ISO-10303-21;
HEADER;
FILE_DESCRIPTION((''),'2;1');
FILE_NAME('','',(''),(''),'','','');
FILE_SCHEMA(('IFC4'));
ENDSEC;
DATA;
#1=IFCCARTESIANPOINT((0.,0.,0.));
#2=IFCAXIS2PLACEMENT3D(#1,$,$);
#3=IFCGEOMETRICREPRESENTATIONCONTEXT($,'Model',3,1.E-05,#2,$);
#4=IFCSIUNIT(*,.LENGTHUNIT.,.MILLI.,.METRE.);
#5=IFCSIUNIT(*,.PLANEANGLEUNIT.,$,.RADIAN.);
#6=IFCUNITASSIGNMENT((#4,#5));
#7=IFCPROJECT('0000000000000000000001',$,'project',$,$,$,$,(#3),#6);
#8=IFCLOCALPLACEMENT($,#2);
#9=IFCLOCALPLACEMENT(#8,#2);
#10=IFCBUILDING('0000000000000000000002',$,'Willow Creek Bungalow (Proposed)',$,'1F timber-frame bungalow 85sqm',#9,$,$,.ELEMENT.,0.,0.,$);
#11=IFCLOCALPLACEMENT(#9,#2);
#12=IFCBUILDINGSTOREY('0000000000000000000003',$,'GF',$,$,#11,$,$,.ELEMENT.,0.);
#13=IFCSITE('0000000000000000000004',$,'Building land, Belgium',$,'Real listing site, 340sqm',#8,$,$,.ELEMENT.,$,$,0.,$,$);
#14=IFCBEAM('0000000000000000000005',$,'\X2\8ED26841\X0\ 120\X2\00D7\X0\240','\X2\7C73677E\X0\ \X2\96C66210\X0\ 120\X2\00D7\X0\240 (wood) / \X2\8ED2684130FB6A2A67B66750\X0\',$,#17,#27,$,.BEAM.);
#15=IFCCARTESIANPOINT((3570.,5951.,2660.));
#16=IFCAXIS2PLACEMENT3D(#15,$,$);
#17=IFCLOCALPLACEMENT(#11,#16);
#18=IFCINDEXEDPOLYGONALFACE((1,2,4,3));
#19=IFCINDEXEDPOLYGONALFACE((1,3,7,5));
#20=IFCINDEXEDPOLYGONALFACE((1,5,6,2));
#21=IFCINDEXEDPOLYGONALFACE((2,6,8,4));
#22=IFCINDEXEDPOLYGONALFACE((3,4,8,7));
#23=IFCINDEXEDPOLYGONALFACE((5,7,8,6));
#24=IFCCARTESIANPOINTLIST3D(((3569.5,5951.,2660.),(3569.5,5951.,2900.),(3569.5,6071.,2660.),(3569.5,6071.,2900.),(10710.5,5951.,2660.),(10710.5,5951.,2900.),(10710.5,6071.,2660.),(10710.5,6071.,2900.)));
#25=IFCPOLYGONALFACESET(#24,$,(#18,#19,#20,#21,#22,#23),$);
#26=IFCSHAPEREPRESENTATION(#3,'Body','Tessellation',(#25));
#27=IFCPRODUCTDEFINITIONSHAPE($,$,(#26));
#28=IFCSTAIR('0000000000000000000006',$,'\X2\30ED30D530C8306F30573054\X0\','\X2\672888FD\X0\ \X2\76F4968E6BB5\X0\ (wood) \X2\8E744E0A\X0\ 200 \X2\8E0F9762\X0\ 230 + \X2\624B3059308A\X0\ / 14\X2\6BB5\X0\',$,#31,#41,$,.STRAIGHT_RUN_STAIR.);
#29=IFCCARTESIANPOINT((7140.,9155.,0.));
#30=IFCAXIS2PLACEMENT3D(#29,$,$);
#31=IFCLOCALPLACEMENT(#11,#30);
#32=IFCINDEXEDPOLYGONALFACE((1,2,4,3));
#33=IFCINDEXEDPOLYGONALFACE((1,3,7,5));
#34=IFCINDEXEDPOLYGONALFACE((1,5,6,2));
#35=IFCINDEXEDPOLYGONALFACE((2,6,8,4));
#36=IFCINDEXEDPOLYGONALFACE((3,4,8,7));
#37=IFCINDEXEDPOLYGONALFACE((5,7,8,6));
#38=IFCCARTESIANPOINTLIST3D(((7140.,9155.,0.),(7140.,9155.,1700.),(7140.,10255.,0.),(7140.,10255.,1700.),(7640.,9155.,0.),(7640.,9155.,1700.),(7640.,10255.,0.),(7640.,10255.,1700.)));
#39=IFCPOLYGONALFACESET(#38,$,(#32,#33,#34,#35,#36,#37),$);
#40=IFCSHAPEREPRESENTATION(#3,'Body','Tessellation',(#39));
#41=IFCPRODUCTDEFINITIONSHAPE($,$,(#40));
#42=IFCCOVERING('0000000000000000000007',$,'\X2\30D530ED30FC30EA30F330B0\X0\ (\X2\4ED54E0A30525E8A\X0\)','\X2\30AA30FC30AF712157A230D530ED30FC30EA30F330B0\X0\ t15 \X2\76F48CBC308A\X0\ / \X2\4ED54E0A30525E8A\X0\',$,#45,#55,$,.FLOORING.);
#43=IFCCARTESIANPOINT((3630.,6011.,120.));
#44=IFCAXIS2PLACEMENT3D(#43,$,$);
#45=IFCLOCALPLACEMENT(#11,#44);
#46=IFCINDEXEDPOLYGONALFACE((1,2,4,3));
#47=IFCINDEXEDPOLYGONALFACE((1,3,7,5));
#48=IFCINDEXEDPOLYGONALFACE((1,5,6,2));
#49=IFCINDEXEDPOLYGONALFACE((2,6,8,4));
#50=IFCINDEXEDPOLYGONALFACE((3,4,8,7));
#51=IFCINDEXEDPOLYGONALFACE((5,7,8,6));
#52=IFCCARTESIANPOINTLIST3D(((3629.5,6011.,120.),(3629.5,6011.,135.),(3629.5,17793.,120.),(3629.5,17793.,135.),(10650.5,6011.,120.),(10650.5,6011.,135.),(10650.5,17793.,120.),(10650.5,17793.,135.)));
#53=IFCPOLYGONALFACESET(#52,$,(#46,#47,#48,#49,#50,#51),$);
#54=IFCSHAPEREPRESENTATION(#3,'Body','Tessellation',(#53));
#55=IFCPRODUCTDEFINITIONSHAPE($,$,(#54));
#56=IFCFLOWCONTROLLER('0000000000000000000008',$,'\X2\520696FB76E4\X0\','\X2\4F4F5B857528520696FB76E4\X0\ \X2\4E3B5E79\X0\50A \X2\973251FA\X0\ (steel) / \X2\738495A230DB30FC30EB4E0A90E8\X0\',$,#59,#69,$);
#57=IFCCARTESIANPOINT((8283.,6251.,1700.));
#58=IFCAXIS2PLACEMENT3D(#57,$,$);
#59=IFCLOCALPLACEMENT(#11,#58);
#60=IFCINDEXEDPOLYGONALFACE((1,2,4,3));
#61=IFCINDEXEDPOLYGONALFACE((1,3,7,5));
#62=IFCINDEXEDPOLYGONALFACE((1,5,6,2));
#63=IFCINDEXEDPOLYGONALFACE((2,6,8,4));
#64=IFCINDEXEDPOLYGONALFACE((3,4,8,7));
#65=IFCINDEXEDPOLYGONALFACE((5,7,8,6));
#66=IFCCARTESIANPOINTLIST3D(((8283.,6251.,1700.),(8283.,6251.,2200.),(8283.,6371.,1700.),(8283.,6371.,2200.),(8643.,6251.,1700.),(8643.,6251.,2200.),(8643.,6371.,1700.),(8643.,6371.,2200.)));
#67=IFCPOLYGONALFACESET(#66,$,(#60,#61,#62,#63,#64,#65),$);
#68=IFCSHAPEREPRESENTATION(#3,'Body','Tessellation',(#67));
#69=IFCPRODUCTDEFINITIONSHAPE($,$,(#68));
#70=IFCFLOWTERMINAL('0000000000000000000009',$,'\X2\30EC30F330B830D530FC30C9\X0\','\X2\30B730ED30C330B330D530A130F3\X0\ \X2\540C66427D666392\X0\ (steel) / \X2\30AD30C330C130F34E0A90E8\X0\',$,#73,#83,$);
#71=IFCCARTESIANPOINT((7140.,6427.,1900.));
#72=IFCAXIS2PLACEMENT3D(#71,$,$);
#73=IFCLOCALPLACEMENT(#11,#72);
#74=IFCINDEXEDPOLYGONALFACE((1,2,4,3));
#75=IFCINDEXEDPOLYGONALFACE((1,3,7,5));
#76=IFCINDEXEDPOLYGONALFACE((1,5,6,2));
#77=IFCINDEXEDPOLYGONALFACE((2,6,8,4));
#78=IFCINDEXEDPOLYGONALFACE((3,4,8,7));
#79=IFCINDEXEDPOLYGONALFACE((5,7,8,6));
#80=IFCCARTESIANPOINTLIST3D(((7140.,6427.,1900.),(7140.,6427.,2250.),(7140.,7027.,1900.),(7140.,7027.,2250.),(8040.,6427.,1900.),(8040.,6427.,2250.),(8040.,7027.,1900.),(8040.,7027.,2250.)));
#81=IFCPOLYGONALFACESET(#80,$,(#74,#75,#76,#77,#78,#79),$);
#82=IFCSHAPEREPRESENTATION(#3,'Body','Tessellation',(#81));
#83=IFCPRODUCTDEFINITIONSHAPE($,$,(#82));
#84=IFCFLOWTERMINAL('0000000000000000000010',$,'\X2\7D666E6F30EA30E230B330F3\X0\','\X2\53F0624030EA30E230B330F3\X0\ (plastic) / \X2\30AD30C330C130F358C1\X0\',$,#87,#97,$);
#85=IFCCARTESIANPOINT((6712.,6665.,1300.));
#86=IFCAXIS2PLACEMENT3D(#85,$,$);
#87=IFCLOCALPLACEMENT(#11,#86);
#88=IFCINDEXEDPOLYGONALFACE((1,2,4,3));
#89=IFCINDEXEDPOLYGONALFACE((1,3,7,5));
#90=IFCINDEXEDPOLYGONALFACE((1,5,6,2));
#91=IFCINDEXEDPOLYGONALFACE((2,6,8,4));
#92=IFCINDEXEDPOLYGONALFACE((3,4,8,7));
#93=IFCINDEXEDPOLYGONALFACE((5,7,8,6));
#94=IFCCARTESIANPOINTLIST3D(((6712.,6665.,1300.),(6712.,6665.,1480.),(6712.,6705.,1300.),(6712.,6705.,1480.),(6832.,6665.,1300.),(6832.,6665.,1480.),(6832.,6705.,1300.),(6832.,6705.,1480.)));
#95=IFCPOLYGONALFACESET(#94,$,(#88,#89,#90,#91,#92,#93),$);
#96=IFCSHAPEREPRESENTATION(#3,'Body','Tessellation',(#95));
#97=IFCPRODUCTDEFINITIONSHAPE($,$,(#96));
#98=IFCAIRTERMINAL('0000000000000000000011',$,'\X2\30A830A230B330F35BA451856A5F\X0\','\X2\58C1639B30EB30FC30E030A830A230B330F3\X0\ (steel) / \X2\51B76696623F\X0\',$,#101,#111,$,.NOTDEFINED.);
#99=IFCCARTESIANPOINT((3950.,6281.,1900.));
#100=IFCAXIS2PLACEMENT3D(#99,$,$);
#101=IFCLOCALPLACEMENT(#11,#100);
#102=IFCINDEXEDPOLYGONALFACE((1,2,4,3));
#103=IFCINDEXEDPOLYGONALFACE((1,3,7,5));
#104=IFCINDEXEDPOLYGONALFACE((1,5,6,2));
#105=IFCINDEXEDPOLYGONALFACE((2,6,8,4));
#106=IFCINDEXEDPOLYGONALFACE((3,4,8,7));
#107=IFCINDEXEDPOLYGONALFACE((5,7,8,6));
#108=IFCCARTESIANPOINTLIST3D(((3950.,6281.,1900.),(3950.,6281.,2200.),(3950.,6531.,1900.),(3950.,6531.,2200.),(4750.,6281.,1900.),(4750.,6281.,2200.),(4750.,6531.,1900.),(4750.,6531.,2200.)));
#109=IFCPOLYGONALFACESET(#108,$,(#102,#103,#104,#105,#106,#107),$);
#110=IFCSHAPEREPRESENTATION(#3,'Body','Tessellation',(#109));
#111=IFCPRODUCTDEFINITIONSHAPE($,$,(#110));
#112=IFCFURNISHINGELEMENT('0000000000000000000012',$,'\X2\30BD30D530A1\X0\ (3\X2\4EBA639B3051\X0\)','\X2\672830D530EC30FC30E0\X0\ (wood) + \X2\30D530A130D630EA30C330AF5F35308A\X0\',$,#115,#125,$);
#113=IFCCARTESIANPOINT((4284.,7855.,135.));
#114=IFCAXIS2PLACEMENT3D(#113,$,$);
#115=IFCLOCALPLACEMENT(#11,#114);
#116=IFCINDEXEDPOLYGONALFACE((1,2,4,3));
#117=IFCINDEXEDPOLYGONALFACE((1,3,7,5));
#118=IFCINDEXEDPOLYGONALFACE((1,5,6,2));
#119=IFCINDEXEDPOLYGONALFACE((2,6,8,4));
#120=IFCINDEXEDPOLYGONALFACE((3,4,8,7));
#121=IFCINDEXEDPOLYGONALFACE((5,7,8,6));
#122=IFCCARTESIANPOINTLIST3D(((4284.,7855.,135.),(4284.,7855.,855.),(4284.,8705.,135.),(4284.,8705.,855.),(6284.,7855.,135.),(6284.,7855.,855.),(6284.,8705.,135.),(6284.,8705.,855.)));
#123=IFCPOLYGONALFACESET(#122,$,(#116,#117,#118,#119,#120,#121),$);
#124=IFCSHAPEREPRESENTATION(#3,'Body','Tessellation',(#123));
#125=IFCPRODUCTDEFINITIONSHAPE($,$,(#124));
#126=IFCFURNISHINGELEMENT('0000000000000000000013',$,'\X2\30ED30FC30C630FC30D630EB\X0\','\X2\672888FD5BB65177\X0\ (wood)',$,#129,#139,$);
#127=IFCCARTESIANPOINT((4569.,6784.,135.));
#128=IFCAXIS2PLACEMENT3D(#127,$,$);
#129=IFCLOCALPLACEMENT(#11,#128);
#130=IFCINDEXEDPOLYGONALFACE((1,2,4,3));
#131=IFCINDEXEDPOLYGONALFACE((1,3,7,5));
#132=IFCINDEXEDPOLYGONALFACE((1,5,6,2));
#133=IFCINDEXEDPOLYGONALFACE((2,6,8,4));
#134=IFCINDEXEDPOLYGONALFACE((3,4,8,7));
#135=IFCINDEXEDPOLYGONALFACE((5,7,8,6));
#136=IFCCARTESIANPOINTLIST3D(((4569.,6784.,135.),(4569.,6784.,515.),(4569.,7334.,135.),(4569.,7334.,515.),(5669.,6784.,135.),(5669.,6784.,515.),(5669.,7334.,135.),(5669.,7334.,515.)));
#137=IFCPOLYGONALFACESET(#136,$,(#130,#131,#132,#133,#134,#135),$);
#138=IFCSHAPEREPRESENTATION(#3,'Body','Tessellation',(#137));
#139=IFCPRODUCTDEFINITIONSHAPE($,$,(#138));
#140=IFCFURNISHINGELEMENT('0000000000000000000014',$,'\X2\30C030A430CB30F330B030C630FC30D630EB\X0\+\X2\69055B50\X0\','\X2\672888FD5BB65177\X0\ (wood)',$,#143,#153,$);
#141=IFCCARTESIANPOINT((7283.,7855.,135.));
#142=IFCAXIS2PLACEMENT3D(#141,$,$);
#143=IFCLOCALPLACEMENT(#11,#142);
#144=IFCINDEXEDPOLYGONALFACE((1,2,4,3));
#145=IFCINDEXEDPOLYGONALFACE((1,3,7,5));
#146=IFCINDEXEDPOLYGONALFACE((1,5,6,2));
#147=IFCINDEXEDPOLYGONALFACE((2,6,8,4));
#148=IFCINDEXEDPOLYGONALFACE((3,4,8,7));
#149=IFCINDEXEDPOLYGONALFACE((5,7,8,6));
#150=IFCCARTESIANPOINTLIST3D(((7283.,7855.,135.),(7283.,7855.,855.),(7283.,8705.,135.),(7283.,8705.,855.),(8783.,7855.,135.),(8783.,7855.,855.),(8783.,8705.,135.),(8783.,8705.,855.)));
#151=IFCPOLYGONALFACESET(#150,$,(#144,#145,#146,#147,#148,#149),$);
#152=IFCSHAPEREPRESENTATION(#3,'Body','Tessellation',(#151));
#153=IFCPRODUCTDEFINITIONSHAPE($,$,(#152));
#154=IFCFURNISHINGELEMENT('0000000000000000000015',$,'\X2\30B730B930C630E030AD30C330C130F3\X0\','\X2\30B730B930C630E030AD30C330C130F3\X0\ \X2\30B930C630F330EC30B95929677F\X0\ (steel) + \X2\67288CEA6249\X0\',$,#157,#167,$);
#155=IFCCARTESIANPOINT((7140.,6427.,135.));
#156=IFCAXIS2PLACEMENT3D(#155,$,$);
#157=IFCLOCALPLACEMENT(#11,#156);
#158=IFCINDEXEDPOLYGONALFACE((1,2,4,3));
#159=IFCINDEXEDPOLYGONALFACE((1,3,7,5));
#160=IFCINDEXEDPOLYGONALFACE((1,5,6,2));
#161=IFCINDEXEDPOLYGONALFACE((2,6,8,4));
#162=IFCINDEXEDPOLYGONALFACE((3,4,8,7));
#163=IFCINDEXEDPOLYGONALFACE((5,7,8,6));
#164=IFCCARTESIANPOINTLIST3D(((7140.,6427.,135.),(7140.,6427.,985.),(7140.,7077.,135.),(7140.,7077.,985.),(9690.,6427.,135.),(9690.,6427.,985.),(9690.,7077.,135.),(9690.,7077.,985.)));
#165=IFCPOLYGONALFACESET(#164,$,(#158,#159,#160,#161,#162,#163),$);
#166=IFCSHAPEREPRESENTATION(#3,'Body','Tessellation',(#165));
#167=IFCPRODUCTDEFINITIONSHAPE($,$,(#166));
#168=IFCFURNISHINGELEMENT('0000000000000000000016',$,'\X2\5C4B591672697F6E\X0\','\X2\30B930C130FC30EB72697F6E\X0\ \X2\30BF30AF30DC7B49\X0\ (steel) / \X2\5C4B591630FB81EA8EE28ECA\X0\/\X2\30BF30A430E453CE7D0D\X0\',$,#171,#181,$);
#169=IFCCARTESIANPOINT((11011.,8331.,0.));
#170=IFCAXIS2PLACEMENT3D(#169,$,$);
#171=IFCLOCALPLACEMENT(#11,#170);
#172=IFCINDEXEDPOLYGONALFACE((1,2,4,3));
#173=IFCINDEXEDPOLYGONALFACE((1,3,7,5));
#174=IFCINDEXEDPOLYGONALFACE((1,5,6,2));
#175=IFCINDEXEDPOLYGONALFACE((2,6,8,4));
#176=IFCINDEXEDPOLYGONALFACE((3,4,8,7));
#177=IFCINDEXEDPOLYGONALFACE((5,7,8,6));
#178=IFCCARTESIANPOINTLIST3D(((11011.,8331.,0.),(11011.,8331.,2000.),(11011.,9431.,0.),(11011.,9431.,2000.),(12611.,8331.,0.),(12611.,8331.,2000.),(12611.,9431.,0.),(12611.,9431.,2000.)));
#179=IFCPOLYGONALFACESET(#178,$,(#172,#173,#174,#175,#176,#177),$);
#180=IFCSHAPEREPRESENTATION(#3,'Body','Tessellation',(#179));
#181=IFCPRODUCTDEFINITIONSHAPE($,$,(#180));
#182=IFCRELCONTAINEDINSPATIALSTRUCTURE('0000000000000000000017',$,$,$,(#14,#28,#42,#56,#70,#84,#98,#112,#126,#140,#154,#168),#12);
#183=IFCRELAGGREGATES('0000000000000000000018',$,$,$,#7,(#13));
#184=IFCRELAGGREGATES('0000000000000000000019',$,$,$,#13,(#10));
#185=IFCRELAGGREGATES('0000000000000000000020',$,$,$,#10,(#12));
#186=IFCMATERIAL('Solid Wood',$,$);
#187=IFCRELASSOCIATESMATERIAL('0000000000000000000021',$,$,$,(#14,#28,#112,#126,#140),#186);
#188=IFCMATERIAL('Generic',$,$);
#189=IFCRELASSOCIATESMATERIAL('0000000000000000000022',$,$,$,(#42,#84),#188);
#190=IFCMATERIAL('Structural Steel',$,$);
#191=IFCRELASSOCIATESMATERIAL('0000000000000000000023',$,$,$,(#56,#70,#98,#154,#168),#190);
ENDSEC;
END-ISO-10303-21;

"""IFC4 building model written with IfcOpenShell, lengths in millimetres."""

from ifc_helpers import new_model, si_unit, frame, frame_2d, origin, place, context, project, spatial, rectangle, extrude, material, element, save


model = new_model("IFC4")

# Units and contexts
model_context = context("Model", 3, precision=1e-05, world=origin())
ifc_project = project(units=[si_unit("LENGTHUNIT", "METRE", prefix="MILLI"), si_unit("PLANEANGLEUNIT", "RADIAN")], contexts=[model_context])

# Site, building, storey
site_placement = place(None, origin())
site = spatial("IfcSite", under=ifc_project, at=site_placement, Name="Building land, Belgium", ObjectType="Real listing site, 340sqm", CompositionType="ELEMENT", RefElevation=0.0)
building_placement = place(site_placement, origin())
building = spatial("IfcBuilding", under=site, at=building_placement, Name="Willow Creek Bungalow (Proposed)", ObjectType="1F timber-frame bungalow 85sqm", CompositionType="ELEMENT", ElevationOfRefHeight=0.0, ElevationOfTerrain=0.0)
storey_placement = place(building_placement, origin())
storey = spatial("IfcBuildingStorey", under=building, at=storey_placement, Name="GF", CompositionType="ELEMENT", Elevation=0.0)

# Shared definitions
ifc_material_1 = material(Name="Solid Wood")

# Beam
beam_1_placement = place(storey_placement, frame((3570.0, 5951.0, 2660.0)))
element("IfcBeam", 1, at=beam_1_placement, inside=storey, material=ifc_material_1, Name="軒桁 120×240", Description="米松 集成 120×240 (wood) / 軒桁・横架材", PredefinedType="BEAM", context=model_context, shape_type="SweptSolid", body=[
    extrude(rectangle(XDim=7141.0, YDim=120.0, at=frame_2d((3570.0, 60.0))), frame((3570.0, 5951.0, 2660.0)), (0.0, 0.0, 1.0), 240.0),
])

# Stair
stair_placement = place(storey_placement, frame((7140.0, 9155.0, 0.0)))
element("IfcStair", 2, at=stair_placement, inside=storey, material=ifc_material_1, Name="ロフトはしご", Description="木製 直階段 (wood) 蹴上 200 踏面 230 + 手すり / 14段", PredefinedType="STRAIGHT_RUN_STAIR", context=model_context, shape_type="SweptSolid", body=[
    extrude(rectangle(XDim=500.0, YDim=1100.0, at=frame_2d((250.0, 550.0))), frame((7140.0, 9155.0, 0.0)), (0.0, 0.0, 1.0), 1700.0),
])

# Covering
ifc_material_2 = material(Name="Generic")
covering_placement = place(storey_placement, frame((3630.0, 6011.0, 120.0)))
element("IfcCovering", 3, at=covering_placement, inside=storey, material=ifc_material_2, Name="フローリング (仕上げ床)", Description="オーク無垢フローリング t15 直貼り / 仕上げ床", PredefinedType="FLOORING", context=model_context, shape_type="SweptSolid", body=[
    extrude(rectangle(XDim=7021.0, YDim=11782.0, at=frame_2d((3510.0, 5891.0))), frame((3630.0, 6011.0, 120.0)), (0.0, 0.0, 1.0), 15.0),
])

# Flow controller
ifc_material_3 = material(Name="Structural Steel")
flow_controller_placement = place(storey_placement, frame((8283.0, 6251.0, 1700.0)))
element("IfcFlowController", 4, at=flow_controller_placement, inside=storey, material=ifc_material_3, Name="分電盤", Description="住宅用分電盤 主幹50A 露出 (steel) / 玄関ホール上部", context=model_context, shape_type="SweptSolid", body=[
    extrude(rectangle(XDim=360.0, YDim=120.0, at=frame_2d((180.0, 60.0))), frame((8283.0, 6251.0, 1700.0)), (0.0, 0.0, 1.0), 500.0),
])

# Flow terminals
flow_terminal_1_placement = place(storey_placement, frame((7140.0, 6427.0, 1900.0)))
element("IfcFlowTerminal", 5, at=flow_terminal_1_placement, inside=storey, material=ifc_material_3, Name="レンジフード", Description="シロッコファン 同時給排 (steel) / キッチン上部", context=model_context, shape_type="SweptSolid", body=[
    extrude(rectangle(XDim=900.0, YDim=600.0, at=frame_2d((450.0, 300.0))), frame((7140.0, 6427.0, 1900.0)), (0.0, 0.0, 1.0), 350.0),
])
flow_terminal_2_placement = place(storey_placement, frame((6712.0, 6665.0, 1300.0)))
element("IfcFlowTerminal", 6, at=flow_terminal_2_placement, inside=storey, material=ifc_material_2, Name="給湯リモコン", Description="台所リモコン (plastic) / キッチン壁", context=model_context, shape_type="SweptSolid", body=[
    extrude(rectangle(XDim=120.0, YDim=40.0, at=frame_2d((60.0, 20.0))), frame((6712.0, 6665.0, 1300.0)), (0.0, 0.0, 1.0), 180.0),
])

# Air terminal
air_terminal_placement = place(storey_placement, frame((3950.0, 6281.0, 1900.0)))
element("IfcAirTerminal", 7, at=air_terminal_placement, inside=storey, material=ifc_material_3, Name="エアコン室内機", Description="壁掛ルームエアコン (steel) / 冷暖房", PredefinedType="NOTDEFINED", context=model_context, shape_type="SweptSolid", body=[
    extrude(rectangle(XDim=800.0, YDim=250.0, at=frame_2d((400.0, 125.0))), frame((3950.0, 6281.0, 1900.0)), (0.0, 0.0, 1.0), 300.0),
])

# Furnishing elements
furnishing_1_placement = place(storey_placement, frame((4284.0, 7855.0, 135.0)))
element("IfcFurnishingElement", 8, at=furnishing_1_placement, inside=storey, material=ifc_material_1, Name="ソファ (3人掛け)", Description="木フレーム (wood) + ファブリック張り", context=model_context, shape_type="SweptSolid", body=[
    extrude(rectangle(XDim=2000.0, YDim=850.0, at=frame_2d((1000.0, 425.0))), frame((4284.0, 7855.0, 135.0)), (0.0, 0.0, 1.0), 720.0),
])
furnishing_2_placement = place(storey_placement, frame((4569.0, 6784.0, 135.0)))
element("IfcFurnishingElement", 9, at=furnishing_2_placement, inside=storey, material=ifc_material_1, Name="ローテーブル", Description="木製家具 (wood)", context=model_context, shape_type="SweptSolid", body=[
    extrude(rectangle(XDim=1100.0, YDim=550.0, at=frame_2d((550.0, 275.0))), frame((4569.0, 6784.0, 135.0)), (0.0, 0.0, 1.0), 380.0),
])
furnishing_3_placement = place(storey_placement, frame((7283.0, 7855.0, 135.0)))
element("IfcFurnishingElement", 10, at=furnishing_3_placement, inside=storey, material=ifc_material_1, Name="ダイニングテーブル+椅子", Description="木製家具 (wood)", context=model_context, shape_type="SweptSolid", body=[
    extrude(rectangle(XDim=1500.0, YDim=850.0, at=frame_2d((750.0, 425.0))), frame((7283.0, 7855.0, 135.0)), (0.0, 0.0, 1.0), 720.0),
])
furnishing_4_placement = place(storey_placement, frame((7140.0, 6427.0, 135.0)))
element("IfcFurnishingElement", 11, at=furnishing_4_placement, inside=storey, material=ifc_material_3, Name="システムキッチン", Description="システムキッチン ステンレス天板 (steel) + 木質扉", context=model_context, shape_type="SweptSolid", body=[
    extrude(rectangle(XDim=2550.0, YDim=650.0, at=frame_2d((1275.0, 325.0))), frame((7140.0, 6427.0, 135.0)), (0.0, 0.0, 1.0), 850.0),
])
furnishing_5_placement = place(storey_placement, frame((11011.0, 8331.0, 0.0)))
element("IfcFurnishingElement", 12, at=furnishing_5_placement, inside=storey, material=ifc_material_3, Name="屋外物置", Description="スチール物置 タクボ等 (steel) / 屋外・自転車/タイヤ収納", context=model_context, shape_type="SweptSolid", body=[
    extrude(rectangle(XDim=1600.0, YDim=1100.0, at=frame_2d((800.0, 550.0))), frame((11011.0, 8331.0, 0.0)), (0.0, 0.0, 1.0), 2000.0),
])

save(model, "model.ifc")
